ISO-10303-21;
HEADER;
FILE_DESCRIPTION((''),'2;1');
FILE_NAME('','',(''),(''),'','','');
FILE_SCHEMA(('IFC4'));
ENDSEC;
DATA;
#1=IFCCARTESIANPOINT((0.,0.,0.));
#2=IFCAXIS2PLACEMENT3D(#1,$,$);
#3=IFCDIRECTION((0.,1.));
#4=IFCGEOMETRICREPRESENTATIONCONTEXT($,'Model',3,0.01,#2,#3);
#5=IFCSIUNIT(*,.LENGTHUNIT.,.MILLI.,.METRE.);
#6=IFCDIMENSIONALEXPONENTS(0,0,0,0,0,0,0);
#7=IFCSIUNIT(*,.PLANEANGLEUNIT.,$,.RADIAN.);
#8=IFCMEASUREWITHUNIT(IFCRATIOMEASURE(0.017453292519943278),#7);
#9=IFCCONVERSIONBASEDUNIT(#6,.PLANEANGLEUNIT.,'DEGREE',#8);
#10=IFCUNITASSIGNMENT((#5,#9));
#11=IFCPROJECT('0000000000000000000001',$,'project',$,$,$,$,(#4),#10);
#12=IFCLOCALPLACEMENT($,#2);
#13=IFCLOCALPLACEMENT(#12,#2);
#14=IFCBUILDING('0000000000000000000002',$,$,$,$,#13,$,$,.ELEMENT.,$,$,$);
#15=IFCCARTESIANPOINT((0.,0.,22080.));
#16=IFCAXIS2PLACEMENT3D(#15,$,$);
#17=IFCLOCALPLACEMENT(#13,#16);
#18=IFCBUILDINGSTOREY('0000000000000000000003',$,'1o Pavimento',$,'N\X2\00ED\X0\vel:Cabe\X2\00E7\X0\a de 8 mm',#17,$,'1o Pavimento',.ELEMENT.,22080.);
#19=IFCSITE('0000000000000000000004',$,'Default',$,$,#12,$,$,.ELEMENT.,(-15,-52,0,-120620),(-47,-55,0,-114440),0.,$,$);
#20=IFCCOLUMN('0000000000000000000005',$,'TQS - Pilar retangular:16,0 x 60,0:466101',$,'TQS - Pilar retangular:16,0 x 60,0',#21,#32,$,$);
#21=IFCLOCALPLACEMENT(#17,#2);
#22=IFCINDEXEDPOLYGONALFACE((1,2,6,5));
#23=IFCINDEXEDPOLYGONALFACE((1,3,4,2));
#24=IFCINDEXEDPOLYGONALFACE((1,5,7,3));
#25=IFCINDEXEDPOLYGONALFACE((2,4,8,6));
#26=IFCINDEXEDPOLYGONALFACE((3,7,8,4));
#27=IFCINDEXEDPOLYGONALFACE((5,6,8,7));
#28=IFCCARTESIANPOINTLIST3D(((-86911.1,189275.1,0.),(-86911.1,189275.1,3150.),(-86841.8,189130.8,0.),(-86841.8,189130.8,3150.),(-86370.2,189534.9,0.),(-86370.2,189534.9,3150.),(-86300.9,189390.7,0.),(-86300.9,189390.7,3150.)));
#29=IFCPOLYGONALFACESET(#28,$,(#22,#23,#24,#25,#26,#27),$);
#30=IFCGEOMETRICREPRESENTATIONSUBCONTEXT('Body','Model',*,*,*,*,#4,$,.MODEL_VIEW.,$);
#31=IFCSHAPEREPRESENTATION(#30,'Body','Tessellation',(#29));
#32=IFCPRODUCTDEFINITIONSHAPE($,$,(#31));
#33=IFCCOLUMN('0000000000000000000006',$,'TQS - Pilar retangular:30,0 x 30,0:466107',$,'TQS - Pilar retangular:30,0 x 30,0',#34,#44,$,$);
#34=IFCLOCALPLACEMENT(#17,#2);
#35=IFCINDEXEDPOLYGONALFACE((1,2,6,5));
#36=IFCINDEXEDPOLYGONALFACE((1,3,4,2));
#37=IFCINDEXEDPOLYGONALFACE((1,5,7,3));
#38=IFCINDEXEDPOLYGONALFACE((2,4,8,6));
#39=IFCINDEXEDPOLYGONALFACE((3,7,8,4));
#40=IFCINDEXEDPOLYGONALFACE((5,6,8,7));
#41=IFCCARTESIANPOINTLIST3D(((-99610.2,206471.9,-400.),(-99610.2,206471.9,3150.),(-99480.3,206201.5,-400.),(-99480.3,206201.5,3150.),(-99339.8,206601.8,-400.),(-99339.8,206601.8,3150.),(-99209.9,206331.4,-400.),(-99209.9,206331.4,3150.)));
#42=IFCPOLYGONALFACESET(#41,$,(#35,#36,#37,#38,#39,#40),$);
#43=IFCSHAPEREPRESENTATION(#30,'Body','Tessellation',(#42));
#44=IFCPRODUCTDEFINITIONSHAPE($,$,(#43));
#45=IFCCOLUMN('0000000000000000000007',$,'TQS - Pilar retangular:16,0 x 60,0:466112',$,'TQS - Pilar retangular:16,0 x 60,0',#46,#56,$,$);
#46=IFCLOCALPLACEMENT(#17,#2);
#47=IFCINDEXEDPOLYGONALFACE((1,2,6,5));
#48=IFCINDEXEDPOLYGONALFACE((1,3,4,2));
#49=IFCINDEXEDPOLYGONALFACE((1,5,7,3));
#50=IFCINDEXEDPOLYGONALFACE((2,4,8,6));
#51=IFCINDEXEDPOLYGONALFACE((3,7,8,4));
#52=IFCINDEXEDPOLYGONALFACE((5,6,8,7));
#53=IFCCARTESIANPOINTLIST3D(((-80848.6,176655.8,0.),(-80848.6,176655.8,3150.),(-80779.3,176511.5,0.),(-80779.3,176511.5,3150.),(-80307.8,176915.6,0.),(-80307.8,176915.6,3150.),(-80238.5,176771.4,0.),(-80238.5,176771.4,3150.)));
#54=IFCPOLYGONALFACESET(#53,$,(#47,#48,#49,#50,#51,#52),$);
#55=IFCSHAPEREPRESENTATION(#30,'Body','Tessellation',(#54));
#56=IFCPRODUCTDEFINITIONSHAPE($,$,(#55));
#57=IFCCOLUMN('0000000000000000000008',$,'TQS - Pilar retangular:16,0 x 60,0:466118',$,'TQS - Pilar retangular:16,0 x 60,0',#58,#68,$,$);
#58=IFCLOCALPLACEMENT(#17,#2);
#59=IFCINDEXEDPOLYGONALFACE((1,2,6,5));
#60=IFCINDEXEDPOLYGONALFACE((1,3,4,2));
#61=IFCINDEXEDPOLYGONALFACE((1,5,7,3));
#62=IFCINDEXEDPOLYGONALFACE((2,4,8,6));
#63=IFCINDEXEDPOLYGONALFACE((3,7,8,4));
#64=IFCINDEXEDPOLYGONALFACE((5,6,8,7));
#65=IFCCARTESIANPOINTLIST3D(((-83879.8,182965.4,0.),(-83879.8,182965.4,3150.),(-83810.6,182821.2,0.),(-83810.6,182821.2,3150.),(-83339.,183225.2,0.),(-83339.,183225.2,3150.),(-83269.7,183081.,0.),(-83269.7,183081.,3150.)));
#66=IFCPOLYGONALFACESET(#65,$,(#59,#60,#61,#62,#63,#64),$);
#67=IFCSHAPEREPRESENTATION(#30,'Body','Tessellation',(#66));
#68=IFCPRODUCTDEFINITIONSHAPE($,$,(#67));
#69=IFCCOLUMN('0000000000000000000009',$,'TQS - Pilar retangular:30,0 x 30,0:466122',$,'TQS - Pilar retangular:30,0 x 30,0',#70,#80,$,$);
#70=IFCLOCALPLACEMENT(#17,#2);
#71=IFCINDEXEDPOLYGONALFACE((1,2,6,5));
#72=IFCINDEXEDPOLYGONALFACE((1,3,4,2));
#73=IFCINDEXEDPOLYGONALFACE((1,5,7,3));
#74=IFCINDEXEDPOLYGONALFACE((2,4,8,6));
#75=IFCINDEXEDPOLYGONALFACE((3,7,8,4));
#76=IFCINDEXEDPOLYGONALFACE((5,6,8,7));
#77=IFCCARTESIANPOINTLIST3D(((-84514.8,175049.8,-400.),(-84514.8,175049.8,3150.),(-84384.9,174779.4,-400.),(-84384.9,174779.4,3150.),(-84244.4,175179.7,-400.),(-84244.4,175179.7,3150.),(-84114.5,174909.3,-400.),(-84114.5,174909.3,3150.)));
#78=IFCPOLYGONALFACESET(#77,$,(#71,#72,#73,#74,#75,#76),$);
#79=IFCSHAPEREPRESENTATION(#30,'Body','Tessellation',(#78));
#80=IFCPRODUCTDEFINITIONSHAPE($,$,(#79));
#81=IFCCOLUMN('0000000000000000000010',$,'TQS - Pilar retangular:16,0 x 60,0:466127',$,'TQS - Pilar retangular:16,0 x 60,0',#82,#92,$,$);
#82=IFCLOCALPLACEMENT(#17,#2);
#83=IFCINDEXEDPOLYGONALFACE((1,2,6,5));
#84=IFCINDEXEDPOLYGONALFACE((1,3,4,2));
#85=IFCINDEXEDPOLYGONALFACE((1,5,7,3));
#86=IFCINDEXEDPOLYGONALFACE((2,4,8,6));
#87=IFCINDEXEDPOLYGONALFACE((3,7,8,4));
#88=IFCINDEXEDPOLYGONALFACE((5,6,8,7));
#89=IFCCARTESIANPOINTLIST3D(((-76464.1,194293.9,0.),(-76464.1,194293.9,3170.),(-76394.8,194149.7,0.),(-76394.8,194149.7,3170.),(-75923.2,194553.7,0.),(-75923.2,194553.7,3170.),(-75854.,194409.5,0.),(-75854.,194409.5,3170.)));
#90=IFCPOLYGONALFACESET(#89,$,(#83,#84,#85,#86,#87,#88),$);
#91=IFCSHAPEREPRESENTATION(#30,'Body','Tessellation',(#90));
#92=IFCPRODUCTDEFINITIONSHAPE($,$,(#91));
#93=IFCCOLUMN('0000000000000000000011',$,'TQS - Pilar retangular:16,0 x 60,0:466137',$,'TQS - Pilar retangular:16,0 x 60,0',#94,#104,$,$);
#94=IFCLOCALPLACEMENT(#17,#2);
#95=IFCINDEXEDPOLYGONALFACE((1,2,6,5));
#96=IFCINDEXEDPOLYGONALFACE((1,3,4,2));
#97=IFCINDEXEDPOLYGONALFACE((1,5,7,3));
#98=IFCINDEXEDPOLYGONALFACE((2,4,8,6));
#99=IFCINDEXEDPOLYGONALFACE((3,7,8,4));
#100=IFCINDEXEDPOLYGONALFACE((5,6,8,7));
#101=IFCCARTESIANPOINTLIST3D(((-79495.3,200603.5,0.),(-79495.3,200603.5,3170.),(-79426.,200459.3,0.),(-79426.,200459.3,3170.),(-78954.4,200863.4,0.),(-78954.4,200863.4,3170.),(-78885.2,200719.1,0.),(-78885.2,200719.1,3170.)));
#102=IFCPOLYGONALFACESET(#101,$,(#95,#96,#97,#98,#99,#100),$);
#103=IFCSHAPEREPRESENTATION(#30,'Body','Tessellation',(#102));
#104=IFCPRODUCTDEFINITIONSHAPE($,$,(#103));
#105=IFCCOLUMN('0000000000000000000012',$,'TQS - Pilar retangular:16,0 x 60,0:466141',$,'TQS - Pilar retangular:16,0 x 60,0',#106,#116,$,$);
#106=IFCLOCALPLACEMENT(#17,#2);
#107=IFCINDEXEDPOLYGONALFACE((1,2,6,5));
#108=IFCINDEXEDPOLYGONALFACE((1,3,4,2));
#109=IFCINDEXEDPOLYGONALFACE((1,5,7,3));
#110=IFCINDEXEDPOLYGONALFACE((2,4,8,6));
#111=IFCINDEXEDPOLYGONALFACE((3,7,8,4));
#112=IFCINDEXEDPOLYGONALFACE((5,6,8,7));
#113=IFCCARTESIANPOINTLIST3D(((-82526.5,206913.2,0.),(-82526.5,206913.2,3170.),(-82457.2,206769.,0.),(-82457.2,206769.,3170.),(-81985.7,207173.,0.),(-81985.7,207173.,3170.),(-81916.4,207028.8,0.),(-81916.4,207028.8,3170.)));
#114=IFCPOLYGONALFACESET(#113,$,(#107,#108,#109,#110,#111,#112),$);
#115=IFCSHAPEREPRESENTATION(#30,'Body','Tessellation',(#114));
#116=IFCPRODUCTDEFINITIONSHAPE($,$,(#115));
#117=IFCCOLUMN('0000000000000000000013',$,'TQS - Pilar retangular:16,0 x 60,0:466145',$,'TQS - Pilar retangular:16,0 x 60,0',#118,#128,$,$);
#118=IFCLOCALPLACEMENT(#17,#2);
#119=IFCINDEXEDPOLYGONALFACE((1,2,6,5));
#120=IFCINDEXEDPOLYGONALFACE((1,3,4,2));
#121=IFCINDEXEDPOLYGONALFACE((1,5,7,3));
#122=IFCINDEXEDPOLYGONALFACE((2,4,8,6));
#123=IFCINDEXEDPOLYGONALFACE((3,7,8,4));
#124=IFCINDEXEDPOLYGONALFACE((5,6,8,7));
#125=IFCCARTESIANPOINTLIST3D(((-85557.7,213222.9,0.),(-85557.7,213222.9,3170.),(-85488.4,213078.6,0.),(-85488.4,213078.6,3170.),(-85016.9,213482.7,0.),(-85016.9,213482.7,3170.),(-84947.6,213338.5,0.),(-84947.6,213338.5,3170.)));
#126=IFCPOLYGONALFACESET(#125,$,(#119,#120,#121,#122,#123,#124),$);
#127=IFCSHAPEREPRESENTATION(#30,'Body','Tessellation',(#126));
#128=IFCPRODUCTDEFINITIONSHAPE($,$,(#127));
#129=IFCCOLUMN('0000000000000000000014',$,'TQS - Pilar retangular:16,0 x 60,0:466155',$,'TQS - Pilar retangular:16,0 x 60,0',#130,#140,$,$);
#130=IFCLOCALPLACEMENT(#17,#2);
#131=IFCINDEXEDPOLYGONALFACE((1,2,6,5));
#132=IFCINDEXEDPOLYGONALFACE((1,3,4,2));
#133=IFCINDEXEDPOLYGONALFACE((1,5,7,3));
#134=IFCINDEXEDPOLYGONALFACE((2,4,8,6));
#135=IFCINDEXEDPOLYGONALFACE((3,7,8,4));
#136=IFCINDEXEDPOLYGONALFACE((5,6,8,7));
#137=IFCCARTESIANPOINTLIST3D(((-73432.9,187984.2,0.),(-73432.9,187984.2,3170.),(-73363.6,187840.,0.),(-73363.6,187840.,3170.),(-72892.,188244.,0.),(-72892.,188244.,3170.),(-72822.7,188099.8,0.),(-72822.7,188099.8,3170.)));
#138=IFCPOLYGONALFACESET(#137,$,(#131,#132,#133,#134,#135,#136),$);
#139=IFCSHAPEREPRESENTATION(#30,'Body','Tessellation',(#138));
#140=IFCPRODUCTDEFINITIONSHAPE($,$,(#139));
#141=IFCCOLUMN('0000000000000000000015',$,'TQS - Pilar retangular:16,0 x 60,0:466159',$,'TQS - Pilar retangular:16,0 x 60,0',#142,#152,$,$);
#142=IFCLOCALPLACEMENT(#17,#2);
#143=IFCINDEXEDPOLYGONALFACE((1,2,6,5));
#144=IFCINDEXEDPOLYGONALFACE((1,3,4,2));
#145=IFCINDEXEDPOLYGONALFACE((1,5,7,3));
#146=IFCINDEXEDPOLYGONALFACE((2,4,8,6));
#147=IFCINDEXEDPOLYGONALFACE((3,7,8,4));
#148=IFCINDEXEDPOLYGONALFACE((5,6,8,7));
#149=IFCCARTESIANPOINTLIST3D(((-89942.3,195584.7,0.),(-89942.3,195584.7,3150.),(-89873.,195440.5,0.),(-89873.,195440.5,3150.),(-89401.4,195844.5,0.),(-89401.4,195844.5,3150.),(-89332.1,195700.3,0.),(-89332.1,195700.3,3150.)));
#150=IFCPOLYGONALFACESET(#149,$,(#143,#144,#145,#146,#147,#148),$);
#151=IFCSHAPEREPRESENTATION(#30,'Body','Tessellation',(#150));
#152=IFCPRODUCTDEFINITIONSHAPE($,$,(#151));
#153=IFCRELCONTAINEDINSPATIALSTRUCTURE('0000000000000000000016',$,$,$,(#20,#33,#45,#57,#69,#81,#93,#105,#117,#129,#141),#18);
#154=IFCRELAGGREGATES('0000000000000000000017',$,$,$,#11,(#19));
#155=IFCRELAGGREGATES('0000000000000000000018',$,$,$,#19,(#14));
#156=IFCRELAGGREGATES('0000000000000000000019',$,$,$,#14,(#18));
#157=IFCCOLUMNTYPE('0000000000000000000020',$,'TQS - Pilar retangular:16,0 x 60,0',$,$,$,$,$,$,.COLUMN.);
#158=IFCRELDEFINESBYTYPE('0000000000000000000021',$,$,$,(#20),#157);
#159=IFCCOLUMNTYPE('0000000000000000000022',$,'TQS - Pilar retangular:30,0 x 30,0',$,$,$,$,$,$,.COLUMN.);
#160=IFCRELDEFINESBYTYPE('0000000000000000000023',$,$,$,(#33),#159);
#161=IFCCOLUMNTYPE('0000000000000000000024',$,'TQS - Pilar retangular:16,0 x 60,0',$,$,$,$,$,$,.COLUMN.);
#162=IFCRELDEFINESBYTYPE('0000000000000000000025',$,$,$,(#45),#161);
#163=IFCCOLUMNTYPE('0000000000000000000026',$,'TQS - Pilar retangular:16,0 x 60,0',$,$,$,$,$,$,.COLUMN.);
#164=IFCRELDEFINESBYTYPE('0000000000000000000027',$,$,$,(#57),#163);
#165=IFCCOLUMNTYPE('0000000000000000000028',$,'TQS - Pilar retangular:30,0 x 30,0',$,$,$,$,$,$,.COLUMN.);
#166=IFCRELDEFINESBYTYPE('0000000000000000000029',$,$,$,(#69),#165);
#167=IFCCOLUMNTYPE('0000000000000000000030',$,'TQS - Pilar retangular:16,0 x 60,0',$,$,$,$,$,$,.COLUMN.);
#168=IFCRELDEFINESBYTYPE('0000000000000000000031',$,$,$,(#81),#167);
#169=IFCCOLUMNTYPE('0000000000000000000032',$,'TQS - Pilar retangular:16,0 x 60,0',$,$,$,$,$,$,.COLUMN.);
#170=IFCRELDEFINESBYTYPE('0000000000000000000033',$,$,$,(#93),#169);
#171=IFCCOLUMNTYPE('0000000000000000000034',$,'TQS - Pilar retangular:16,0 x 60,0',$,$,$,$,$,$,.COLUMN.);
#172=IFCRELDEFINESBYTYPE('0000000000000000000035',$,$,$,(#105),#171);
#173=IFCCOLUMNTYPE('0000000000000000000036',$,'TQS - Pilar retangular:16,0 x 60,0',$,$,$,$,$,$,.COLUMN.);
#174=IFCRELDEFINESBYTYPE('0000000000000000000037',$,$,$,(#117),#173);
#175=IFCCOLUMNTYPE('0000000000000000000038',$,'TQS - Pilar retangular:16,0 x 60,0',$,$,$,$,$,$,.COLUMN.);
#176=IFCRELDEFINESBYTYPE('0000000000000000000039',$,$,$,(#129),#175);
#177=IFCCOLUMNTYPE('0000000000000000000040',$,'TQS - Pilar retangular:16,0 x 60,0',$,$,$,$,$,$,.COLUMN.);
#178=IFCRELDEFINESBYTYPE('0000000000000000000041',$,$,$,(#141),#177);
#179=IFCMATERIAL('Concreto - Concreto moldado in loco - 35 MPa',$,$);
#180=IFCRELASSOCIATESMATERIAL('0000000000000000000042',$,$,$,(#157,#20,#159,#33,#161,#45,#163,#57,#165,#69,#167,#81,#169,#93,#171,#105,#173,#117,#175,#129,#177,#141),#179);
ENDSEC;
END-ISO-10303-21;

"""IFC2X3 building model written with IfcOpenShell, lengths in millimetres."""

from ifc_helpers import new_model, entity, si_unit, converted_unit, direction, frame, origin, origin_2d_with_axis, place, context, subcontext, project, spatial, rectangle, extrude, source, transform, mapped, material, type_object, type_shapes, element, save


model = new_model("IFC2X3")

# Units and contexts
model_context = context("Model", 3, precision=0.01, world=origin(), true_north=direction((0.0, 1.0)))
body_context = subcontext(model_context, "Body", "Model", "MODEL_VIEW")
ifc_project = project(units=[si_unit("LENGTHUNIT", "METRE", prefix="MILLI"), converted_unit("PLANEANGLEUNIT", "DEGREE", entity("IfcRatioMeasure", 0.017453292519943278), si_unit("PLANEANGLEUNIT", "RADIAN"), dimensions=[0, 0, 0, 0, 0, 0, 0])], contexts=[model_context])

# Site, building, storey
site_placement = place(None, origin())
site = spatial("IfcSite", under=ifc_project, at=site_placement, Name="Default", CompositionType="ELEMENT", RefLatitude=(-15, -52, 0, -120620), RefLongitude=(-47, -55, 0, -114440), RefElevation=0.0)
building_placement = place(site_placement, origin())
building = spatial("IfcBuilding", under=site, at=building_placement, CompositionType="ELEMENT")
storey_placement = place(building_placement, frame((0.0, 0.0, 22080.0)))
storey = spatial("IfcBuildingStorey", under=building, at=storey_placement, Name="1o Pavimento", ObjectType="Nível:Cabeça de 8 mm", LongName="1o Pavimento", CompositionType="ELEMENT", Elevation=22080.0)

# Columns
ifc_material = material(Name="Concreto - Concreto moldado in loco - 35 MPa")
column_type_1 = type_object("IfcColumnType", Name="TQS - Pilar retangular:16,0 x 60,0", PredefinedType="COLUMN", material=ifc_material)
shared_shape_1 = source(origin(), body_context, "Body", "SweptSolid", [
    extrude(rectangle(XDim=600.0, YDim=160.0, at=origin_2d_with_axis()), frame((-86606.0, 189332.9, 22080.0), z_axis=(0.0, 0.0, 1.0), x_axis=(-0.90138, -0.43303, 0.0)), (0.0, 0.0, 1.0), 3150.0),
])
type_shapes(column_type_1, [shared_shape_1])
column_1_placement = place(storey_placement, frame((0.0, 0.0, -22080.0)))
element("IfcColumn", 1, at=column_1_placement, inside=storey, type_object=column_type_1, material=ifc_material, Name="TQS - Pilar retangular:16,0 x 60,0:466101", ObjectType="TQS - Pilar retangular:16,0 x 60,0", context=body_context, shape_type="MappedRepresentation", body=[
    mapped(shared_shape_1, transform((0.0, 0.0, 0.0), scale=1.0)),
])
column_type_2 = type_object("IfcColumnType", Name="TQS - Pilar retangular:30,0 x 30,0", PredefinedType="COLUMN", material=ifc_material)
shared_shape_2 = source(origin(), body_context, "Body", "SweptSolid", [
    extrude(rectangle(XDim=300.0, YDim=300.0, at=origin_2d_with_axis()), frame((-99410.0, 206401.7, 21680.0), z_axis=(0.0, 0.0, 1.0), x_axis=(-0.90138, -0.43303, 0.0)), (0.0, 0.0, 1.0), 3550.0),
])
type_shapes(column_type_2, [shared_shape_2])
column_2_placement = place(storey_placement, frame((0.0, 0.0, -22080.0)))
element("IfcColumn", 2, at=column_2_placement, inside=storey, type_object=column_type_2, material=ifc_material, Name="TQS - Pilar retangular:30,0 x 30,0:466107", ObjectType="TQS - Pilar retangular:30,0 x 30,0", context=body_context, shape_type="MappedRepresentation", body=[
    mapped(shared_shape_2, transform((0.0, 0.0, 0.0), scale=1.0)),
])
column_type_3 = type_object("IfcColumnType", Name="TQS - Pilar retangular:16,0 x 60,0", PredefinedType="COLUMN", material=ifc_material)
shared_shape_3 = source(origin(), body_context, "Body", "SweptSolid", [
    extrude(rectangle(XDim=600.0, YDim=160.0, at=origin_2d_with_axis()), frame((-80543.6, 176713.6, 22080.0), z_axis=(0.0, 0.0, 1.0), x_axis=(-0.90138, -0.43303, 0.0)), (0.0, 0.0, 1.0), 3150.0),
])
type_shapes(column_type_3, [shared_shape_3])
column_3_placement = place(storey_placement, frame((0.0, 0.0, -22080.0)))
element("IfcColumn", 3, at=column_3_placement, inside=storey, type_object=column_type_3, material=ifc_material, Name="TQS - Pilar retangular:16,0 x 60,0:466112", ObjectType="TQS - Pilar retangular:16,0 x 60,0", context=body_context, shape_type="MappedRepresentation", body=[
    mapped(shared_shape_3, transform((0.0, 0.0, 0.0), scale=1.0)),
])
column_type_4 = type_object("IfcColumnType", Name="TQS - Pilar retangular:16,0 x 60,0", PredefinedType="COLUMN", material=ifc_material)
shared_shape_4 = source(origin(), body_context, "Body", "SweptSolid", [
    extrude(rectangle(XDim=600.0, YDim=160.0, at=origin_2d_with_axis()), frame((-83574.8, 183023.2, 22080.0), z_axis=(0.0, 0.0, 1.0), x_axis=(-0.90138, -0.43303, 0.0)), (0.0, 0.0, 1.0), 3150.0),
])
type_shapes(column_type_4, [shared_shape_4])
column_4_placement = place(storey_placement, frame((0.0, 0.0, -22080.0)))
element("IfcColumn", 4, at=column_4_placement, inside=storey, type_object=column_type_4, material=ifc_material, Name="TQS - Pilar retangular:16,0 x 60,0:466118", ObjectType="TQS - Pilar retangular:16,0 x 60,0", context=body_context, shape_type="MappedRepresentation", body=[
    mapped(shared_shape_4, transform((0.0, 0.0, 0.0), scale=1.0)),
])
column_type_5 = type_object("IfcColumnType", Name="TQS - Pilar retangular:30,0 x 30,0", PredefinedType="COLUMN", material=ifc_material)
shared_shape_5 = source(origin(), body_context, "Body", "SweptSolid", [
    extrude(rectangle(XDim=300.0, YDim=300.0, at=origin_2d_with_axis()), frame((-84314.6, 174979.6, 21680.0), z_axis=(0.0, 0.0, 1.0), x_axis=(-0.90138, -0.43303, 0.0)), (0.0, 0.0, 1.0), 3550.0),
])
type_shapes(column_type_5, [shared_shape_5])
column_5_placement = place(storey_placement, frame((0.0, 0.0, -22080.0)))
element("IfcColumn", 5, at=column_5_placement, inside=storey, type_object=column_type_5, material=ifc_material, Name="TQS - Pilar retangular:30,0 x 30,0:466122", ObjectType="TQS - Pilar retangular:30,0 x 30,0", context=body_context, shape_type="MappedRepresentation", body=[
    mapped(shared_shape_5, transform((0.0, 0.0, 0.0), scale=1.0)),
])
column_type_6 = type_object("IfcColumnType", Name="TQS - Pilar retangular:16,0 x 60,0", PredefinedType="COLUMN", material=ifc_material)
shared_shape_6 = source(origin(), body_context, "Body", "SweptSolid", [
    extrude(rectangle(XDim=600.0, YDim=160.0, at=origin_2d_with_axis()), frame((-76159.0, 194351.7, 22080.0), z_axis=(0.0, 0.0, 1.0), x_axis=(-0.90138, -0.43303, 0.0)), (0.0, 0.0, 1.0), 3170.0),
])
type_shapes(column_type_6, [shared_shape_6])
column_6_placement = place(storey_placement, frame((0.0, 0.0, -22080.0)))
element("IfcColumn", 6, at=column_6_placement, inside=storey, type_object=column_type_6, material=ifc_material, Name="TQS - Pilar retangular:16,0 x 60,0:466127", ObjectType="TQS - Pilar retangular:16,0 x 60,0", context=body_context, shape_type="MappedRepresentation", body=[
    mapped(shared_shape_6, transform((0.0, 0.0, 0.0), scale=1.0)),
])
column_type_7 = type_object("IfcColumnType", Name="TQS - Pilar retangular:16,0 x 60,0", PredefinedType="COLUMN", material=ifc_material)
shared_shape_7 = source(origin(), body_context, "Body", "SweptSolid", [
    extrude(rectangle(XDim=600.0, YDim=160.0, at=origin_2d_with_axis()), frame((-79190.2, 200661.3, 22080.0), z_axis=(0.0, 0.0, 1.0), x_axis=(-0.90138, -0.43303, 0.0)), (0.0, 0.0, 1.0), 3170.0),
])
type_shapes(column_type_7, [shared_shape_7])
column_7_placement = place(storey_placement, frame((0.0, 0.0, -22080.0)))
element("IfcColumn", 7, at=column_7_placement, inside=storey, type_object=column_type_7, material=ifc_material, Name="TQS - Pilar retangular:16,0 x 60,0:466137", ObjectType="TQS - Pilar retangular:16,0 x 60,0", context=body_context, shape_type="MappedRepresentation", body=[
    mapped(shared_shape_7, transform((0.0, 0.0, 0.0), scale=1.0)),
])
column_type_8 = type_object("IfcColumnType", Name="TQS - Pilar retangular:16,0 x 60,0", PredefinedType="COLUMN", material=ifc_material)
shared_shape_8 = source(origin(), body_context, "Body", "SweptSolid", [
    extrude(rectangle(XDim=600.0, YDim=160.0, at=origin_2d_with_axis()), frame((-82221.4, 206971.0, 22080.0), z_axis=(0.0, 0.0, 1.0), x_axis=(-0.90138, -0.43303, 0.0)), (0.0, 0.0, 1.0), 3170.0),
])
type_shapes(column_type_8, [shared_shape_8])
column_8_placement = place(storey_placement, frame((0.0, 0.0, -22080.0)))
element("IfcColumn", 8, at=column_8_placement, inside=storey, type_object=column_type_8, material=ifc_material, Name="TQS - Pilar retangular:16,0 x 60,0:466141", ObjectType="TQS - Pilar retangular:16,0 x 60,0", context=body_context, shape_type="MappedRepresentation", body=[
    mapped(shared_shape_8, transform((0.0, 0.0, 0.0), scale=1.0)),
])
column_type_9 = type_object("IfcColumnType", Name="TQS - Pilar retangular:16,0 x 60,0", PredefinedType="COLUMN", material=ifc_material)
shared_shape_9 = source(origin(), body_context, "Body", "SweptSolid", [
    extrude(rectangle(XDim=600.0, YDim=160.0, at=origin_2d_with_axis()), frame((-85252.6, 213280.7, 22080.0), z_axis=(0.0, 0.0, 1.0), x_axis=(-0.90138, -0.43303, 0.0)), (0.0, 0.0, 1.0), 3170.0),
])
type_shapes(column_type_9, [shared_shape_9])
column_9_placement = place(storey_placement, frame((0.0, 0.0, -22080.0)))
element("IfcColumn", 9, at=column_9_placement, inside=storey, type_object=column_type_9, material=ifc_material, Name="TQS - Pilar retangular:16,0 x 60,0:466145", ObjectType="TQS - Pilar retangular:16,0 x 60,0", context=body_context, shape_type="MappedRepresentation", body=[
    mapped(shared_shape_9, transform((0.0, 0.0, 0.0), scale=1.0)),
])
column_type_10 = type_object("IfcColumnType", Name="TQS - Pilar retangular:16,0 x 60,0", PredefinedType="COLUMN", material=ifc_material)
shared_shape_10 = source(origin(), body_context, "Body", "SweptSolid", [
    extrude(rectangle(XDim=600.0, YDim=160.0, at=origin_2d_with_axis()), frame((-73127.8, 188042.0, 22080.0), z_axis=(0.0, 0.0, 1.0), x_axis=(-0.90138, -0.43303, 0.0)), (0.0, 0.0, 1.0), 3170.0),
])
type_shapes(column_type_10, [shared_shape_10])
column_10_placement = place(storey_placement, frame((0.0, 0.0, -22080.0)))
element("IfcColumn", 10, at=column_10_placement, inside=storey, type_object=column_type_10, material=ifc_material, Name="TQS - Pilar retangular:16,0 x 60,0:466155", ObjectType="TQS - Pilar retangular:16,0 x 60,0", context=body_context, shape_type="MappedRepresentation", body=[
    mapped(shared_shape_10, transform((0.0, 0.0, 0.0), scale=1.0)),
])
column_type_11 = type_object("IfcColumnType", Name="TQS - Pilar retangular:16,0 x 60,0", PredefinedType="COLUMN", material=ifc_material)
shared_shape_11 = source(origin(), body_context, "Body", "SweptSolid", [
    extrude(rectangle(XDim=600.0, YDim=160.0, at=origin_2d_with_axis()), frame((-89637.2, 195642.5, 22080.0), z_axis=(0.0, 0.0, 1.0), x_axis=(-0.90138, -0.43303, 0.0)), (0.0, 0.0, 1.0), 3150.0),
])
type_shapes(column_type_11, [shared_shape_11])
column_11_placement = place(storey_placement, frame((0.0, 0.0, -22080.0)))
element("IfcColumn", 11, at=column_11_placement, inside=storey, type_object=column_type_11, material=ifc_material, Name="TQS - Pilar retangular:16,0 x 60,0:466159", ObjectType="TQS - Pilar retangular:16,0 x 60,0", context=body_context, shape_type="MappedRepresentation", body=[
    mapped(shared_shape_11, transform((0.0, 0.0, 0.0), scale=1.0)),
])

save(model, "model.ifc")
